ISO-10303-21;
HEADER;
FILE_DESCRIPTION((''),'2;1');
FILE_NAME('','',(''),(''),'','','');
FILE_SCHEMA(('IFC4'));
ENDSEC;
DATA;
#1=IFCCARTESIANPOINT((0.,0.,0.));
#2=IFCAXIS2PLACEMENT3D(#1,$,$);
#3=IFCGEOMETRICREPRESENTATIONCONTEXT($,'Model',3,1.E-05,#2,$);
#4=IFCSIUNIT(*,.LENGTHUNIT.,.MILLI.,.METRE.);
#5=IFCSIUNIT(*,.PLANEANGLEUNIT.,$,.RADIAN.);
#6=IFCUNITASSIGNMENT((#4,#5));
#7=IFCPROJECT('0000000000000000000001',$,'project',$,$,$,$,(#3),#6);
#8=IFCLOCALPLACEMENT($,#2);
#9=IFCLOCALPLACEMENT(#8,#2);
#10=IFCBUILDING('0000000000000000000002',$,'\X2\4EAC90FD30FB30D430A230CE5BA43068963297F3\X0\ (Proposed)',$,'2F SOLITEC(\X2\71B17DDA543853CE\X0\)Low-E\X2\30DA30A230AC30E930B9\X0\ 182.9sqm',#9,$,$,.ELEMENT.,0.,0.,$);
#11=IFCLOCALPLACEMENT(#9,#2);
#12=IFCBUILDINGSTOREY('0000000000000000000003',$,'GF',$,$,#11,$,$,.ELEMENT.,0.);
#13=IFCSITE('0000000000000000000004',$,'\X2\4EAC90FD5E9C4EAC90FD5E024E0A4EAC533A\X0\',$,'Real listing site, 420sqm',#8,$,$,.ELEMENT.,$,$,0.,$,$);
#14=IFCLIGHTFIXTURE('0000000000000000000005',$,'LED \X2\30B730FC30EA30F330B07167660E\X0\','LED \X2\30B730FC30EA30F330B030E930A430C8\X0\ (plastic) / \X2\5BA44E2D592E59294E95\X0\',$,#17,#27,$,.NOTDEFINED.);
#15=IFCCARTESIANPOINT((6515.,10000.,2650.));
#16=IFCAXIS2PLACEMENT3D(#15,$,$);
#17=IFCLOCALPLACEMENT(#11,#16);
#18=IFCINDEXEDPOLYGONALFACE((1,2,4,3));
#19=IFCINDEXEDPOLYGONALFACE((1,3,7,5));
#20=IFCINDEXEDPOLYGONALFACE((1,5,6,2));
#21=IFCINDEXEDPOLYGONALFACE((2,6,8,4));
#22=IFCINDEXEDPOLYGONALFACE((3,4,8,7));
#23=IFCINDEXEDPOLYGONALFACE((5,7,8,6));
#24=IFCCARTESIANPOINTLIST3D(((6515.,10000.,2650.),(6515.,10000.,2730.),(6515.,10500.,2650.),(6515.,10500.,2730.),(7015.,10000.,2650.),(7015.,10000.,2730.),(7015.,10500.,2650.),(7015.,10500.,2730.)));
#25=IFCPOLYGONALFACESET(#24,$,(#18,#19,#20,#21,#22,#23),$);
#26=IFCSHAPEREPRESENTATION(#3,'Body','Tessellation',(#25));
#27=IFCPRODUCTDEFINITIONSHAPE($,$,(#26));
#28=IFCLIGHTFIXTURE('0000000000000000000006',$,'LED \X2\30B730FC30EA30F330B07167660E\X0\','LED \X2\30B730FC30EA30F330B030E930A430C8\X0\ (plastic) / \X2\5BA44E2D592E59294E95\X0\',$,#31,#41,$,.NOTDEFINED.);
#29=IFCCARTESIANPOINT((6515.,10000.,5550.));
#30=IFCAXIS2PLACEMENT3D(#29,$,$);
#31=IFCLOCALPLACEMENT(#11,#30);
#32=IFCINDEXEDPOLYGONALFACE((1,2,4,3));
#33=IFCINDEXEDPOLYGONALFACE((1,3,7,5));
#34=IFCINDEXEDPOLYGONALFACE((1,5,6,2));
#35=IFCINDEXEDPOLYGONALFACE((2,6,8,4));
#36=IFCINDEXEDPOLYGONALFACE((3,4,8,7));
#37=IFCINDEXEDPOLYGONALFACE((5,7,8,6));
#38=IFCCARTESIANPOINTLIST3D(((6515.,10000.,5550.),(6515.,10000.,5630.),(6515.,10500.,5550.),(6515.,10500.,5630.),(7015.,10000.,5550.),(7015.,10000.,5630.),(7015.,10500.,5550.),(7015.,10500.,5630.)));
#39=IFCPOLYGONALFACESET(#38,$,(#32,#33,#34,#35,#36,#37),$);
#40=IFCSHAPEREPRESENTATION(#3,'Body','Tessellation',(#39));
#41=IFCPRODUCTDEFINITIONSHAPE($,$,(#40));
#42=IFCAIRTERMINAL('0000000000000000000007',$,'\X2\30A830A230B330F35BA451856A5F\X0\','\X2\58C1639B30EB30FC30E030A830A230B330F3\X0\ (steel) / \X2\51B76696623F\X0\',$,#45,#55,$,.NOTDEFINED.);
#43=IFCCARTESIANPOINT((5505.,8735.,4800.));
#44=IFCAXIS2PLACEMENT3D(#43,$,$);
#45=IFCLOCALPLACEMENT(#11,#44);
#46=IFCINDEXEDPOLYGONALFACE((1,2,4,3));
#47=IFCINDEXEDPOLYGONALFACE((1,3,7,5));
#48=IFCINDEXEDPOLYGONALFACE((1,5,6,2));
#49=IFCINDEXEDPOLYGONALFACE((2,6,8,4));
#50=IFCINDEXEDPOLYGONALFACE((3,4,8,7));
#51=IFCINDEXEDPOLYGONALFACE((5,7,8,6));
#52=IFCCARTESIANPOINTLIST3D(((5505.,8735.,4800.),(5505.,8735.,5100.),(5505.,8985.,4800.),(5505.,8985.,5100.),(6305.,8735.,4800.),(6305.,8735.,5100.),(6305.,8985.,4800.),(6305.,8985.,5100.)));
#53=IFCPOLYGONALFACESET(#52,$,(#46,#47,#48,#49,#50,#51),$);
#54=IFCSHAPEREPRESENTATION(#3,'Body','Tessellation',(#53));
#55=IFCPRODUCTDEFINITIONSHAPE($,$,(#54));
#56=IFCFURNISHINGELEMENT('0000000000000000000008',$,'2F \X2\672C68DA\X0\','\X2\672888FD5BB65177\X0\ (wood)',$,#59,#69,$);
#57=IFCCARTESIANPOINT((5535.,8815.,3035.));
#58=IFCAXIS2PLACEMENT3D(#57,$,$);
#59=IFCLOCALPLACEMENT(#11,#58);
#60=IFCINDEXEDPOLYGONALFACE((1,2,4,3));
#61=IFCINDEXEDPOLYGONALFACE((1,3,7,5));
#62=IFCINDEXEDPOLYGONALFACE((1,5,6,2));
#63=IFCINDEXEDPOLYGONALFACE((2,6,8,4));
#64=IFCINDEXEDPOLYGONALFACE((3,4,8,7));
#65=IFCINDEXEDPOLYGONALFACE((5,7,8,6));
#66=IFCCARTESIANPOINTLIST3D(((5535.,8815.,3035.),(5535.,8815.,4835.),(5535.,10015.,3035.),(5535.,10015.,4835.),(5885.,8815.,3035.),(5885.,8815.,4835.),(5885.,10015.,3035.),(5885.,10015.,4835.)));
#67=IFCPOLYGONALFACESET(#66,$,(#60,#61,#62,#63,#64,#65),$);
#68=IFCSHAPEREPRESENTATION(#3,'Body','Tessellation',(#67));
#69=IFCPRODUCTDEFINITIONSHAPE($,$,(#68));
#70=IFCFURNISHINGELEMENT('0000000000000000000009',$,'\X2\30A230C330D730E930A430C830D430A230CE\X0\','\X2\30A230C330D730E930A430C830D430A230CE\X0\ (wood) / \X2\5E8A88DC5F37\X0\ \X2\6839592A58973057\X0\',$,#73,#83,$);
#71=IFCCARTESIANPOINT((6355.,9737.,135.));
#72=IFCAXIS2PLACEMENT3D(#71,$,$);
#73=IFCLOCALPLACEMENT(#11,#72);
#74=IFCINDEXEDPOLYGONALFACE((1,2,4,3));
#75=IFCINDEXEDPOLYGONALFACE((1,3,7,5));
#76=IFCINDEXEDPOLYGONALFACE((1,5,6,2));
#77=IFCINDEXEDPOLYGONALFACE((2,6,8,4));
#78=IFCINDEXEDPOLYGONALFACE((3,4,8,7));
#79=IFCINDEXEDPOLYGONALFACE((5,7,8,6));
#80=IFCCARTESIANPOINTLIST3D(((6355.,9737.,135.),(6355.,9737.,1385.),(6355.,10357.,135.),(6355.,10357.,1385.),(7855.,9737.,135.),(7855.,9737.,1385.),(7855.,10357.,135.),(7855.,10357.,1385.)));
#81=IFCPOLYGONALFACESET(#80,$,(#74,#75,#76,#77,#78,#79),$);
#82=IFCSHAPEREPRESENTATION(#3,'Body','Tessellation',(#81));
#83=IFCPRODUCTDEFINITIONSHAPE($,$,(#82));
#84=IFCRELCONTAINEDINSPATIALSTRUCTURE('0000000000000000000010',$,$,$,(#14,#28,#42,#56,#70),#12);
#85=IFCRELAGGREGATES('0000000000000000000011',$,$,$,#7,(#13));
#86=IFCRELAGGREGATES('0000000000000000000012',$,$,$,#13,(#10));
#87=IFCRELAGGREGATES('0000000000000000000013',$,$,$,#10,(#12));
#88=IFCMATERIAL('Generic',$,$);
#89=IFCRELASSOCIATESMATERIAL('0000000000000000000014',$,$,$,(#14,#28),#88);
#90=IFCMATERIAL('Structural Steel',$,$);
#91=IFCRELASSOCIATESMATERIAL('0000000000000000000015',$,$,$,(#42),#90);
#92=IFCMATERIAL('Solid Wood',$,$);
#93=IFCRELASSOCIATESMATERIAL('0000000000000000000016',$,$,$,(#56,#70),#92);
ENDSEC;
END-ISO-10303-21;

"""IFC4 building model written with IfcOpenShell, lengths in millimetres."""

from ifc_helpers import new_model, si_unit, frame, frame_2d, origin, place, context, project, spatial, rectangle, extrude, material, element, save


model = new_model("IFC4")

# Units and contexts
model_context = context("Model", 3, precision=1e-05, world=origin())
ifc_project = project(units=[si_unit("LENGTHUNIT", "METRE", prefix="MILLI"), si_unit("PLANEANGLEUNIT", "RADIAN")], contexts=[model_context])

# Site, building, storey
site_placement = place(None, origin())
site = spatial("IfcSite", under=ifc_project, at=site_placement, Name="京都府京都市上京区", ObjectType="Real listing site, 420sqm", CompositionType="ELEMENT", RefElevation=0.0)
building_placement = place(site_placement, origin())
building = spatial("IfcBuilding", under=site, at=building_placement, Name="京都・ピアノ室と防音 (Proposed)", ObjectType="2F SOLITEC(熱線吸収)Low-Eペアガラス 182.9sqm", CompositionType="ELEMENT", ElevationOfRefHeight=0.0, ElevationOfTerrain=0.0)
storey_placement = place(building_placement, origin())
storey = spatial("IfcBuildingStorey", under=building, at=storey_placement, Name="GF", CompositionType="ELEMENT", Elevation=0.0)

# Shared definitions
ifc_material_1 = material(Name="Solid Wood")

# Shared definitions
ifc_material_2 = material(Name="Structural Steel")

# Shared definitions
ifc_material_3 = material(Name="Generic")

# Light fixtures
light_fixture_1_placement = place(storey_placement, frame((6515.0, 10000.0, 2650.0)))
element("IfcLightFixture", 1, at=light_fixture_1_placement, inside=storey, material=ifc_material_3, Name="LED シーリング照明", Description="LED シーリングライト (plastic) / 室中央天井", PredefinedType="NOTDEFINED", context=model_context, shape_type="SweptSolid", body=[
    extrude(rectangle(XDim=500.0, YDim=500.0, at=frame_2d((250.0, 250.0))), frame((6515.0, 10000.0, 2650.0)), (0.0, 0.0, 1.0), 80.0),
])
light_fixture_2_placement = place(storey_placement, frame((6515.0, 10000.0, 5550.0)))
element("IfcLightFixture", 2, at=light_fixture_2_placement, inside=storey, material=ifc_material_3, Name="LED シーリング照明", Description="LED シーリングライト (plastic) / 室中央天井", PredefinedType="NOTDEFINED", context=model_context, shape_type="SweptSolid", body=[
    extrude(rectangle(XDim=500.0, YDim=500.0, at=frame_2d((250.0, 250.0))), frame((6515.0, 10000.0, 5550.0)), (0.0, 0.0, 1.0), 80.0),
])

# Air terminal
air_terminal_placement = place(storey_placement, frame((5505.0, 8735.0, 4800.0)))
element("IfcAirTerminal", 3, at=air_terminal_placement, inside=storey, material=ifc_material_2, Name="エアコン室内機", Description="壁掛ルームエアコン (steel) / 冷暖房", PredefinedType="NOTDEFINED", context=model_context, shape_type="SweptSolid", body=[
    extrude(rectangle(XDim=800.0, YDim=250.0, at=frame_2d((400.0, 125.0))), frame((5505.0, 8735.0, 4800.0)), (0.0, 0.0, 1.0), 300.0),
])

# Furnishing elements
furnishing_1_placement = place(storey_placement, frame((5535.0, 8815.0, 3035.0)))
element("IfcFurnishingElement", 4, at=furnishing_1_placement, inside=storey, material=ifc_material_1, Name="2F 本棚", Description="木製家具 (wood)", context=model_context, shape_type="SweptSolid", body=[
    extrude(rectangle(XDim=350.0, YDim=1200.0, at=frame_2d((175.0, 600.0))), frame((5535.0, 8815.0, 3035.0)), (0.0, 0.0, 1.0), 1800.0),
])
furnishing_2_placement = place(storey_placement, frame((6355.0, 9737.0, 135.0)))
element("IfcFurnishingElement", 5, at=furnishing_2_placement, inside=storey, material=ifc_material_1, Name="アップライトピアノ", Description="アップライトピアノ (wood) / 床補強 根太増し", context=model_context, shape_type="SweptSolid", body=[
    extrude(rectangle(XDim=1500.0, YDim=620.0, at=frame_2d((750.0, 310.0))), frame((6355.0, 9737.0, 135.0)), (0.0, 0.0, 1.0), 1250.0),
])

save(model, "model.ifc")
